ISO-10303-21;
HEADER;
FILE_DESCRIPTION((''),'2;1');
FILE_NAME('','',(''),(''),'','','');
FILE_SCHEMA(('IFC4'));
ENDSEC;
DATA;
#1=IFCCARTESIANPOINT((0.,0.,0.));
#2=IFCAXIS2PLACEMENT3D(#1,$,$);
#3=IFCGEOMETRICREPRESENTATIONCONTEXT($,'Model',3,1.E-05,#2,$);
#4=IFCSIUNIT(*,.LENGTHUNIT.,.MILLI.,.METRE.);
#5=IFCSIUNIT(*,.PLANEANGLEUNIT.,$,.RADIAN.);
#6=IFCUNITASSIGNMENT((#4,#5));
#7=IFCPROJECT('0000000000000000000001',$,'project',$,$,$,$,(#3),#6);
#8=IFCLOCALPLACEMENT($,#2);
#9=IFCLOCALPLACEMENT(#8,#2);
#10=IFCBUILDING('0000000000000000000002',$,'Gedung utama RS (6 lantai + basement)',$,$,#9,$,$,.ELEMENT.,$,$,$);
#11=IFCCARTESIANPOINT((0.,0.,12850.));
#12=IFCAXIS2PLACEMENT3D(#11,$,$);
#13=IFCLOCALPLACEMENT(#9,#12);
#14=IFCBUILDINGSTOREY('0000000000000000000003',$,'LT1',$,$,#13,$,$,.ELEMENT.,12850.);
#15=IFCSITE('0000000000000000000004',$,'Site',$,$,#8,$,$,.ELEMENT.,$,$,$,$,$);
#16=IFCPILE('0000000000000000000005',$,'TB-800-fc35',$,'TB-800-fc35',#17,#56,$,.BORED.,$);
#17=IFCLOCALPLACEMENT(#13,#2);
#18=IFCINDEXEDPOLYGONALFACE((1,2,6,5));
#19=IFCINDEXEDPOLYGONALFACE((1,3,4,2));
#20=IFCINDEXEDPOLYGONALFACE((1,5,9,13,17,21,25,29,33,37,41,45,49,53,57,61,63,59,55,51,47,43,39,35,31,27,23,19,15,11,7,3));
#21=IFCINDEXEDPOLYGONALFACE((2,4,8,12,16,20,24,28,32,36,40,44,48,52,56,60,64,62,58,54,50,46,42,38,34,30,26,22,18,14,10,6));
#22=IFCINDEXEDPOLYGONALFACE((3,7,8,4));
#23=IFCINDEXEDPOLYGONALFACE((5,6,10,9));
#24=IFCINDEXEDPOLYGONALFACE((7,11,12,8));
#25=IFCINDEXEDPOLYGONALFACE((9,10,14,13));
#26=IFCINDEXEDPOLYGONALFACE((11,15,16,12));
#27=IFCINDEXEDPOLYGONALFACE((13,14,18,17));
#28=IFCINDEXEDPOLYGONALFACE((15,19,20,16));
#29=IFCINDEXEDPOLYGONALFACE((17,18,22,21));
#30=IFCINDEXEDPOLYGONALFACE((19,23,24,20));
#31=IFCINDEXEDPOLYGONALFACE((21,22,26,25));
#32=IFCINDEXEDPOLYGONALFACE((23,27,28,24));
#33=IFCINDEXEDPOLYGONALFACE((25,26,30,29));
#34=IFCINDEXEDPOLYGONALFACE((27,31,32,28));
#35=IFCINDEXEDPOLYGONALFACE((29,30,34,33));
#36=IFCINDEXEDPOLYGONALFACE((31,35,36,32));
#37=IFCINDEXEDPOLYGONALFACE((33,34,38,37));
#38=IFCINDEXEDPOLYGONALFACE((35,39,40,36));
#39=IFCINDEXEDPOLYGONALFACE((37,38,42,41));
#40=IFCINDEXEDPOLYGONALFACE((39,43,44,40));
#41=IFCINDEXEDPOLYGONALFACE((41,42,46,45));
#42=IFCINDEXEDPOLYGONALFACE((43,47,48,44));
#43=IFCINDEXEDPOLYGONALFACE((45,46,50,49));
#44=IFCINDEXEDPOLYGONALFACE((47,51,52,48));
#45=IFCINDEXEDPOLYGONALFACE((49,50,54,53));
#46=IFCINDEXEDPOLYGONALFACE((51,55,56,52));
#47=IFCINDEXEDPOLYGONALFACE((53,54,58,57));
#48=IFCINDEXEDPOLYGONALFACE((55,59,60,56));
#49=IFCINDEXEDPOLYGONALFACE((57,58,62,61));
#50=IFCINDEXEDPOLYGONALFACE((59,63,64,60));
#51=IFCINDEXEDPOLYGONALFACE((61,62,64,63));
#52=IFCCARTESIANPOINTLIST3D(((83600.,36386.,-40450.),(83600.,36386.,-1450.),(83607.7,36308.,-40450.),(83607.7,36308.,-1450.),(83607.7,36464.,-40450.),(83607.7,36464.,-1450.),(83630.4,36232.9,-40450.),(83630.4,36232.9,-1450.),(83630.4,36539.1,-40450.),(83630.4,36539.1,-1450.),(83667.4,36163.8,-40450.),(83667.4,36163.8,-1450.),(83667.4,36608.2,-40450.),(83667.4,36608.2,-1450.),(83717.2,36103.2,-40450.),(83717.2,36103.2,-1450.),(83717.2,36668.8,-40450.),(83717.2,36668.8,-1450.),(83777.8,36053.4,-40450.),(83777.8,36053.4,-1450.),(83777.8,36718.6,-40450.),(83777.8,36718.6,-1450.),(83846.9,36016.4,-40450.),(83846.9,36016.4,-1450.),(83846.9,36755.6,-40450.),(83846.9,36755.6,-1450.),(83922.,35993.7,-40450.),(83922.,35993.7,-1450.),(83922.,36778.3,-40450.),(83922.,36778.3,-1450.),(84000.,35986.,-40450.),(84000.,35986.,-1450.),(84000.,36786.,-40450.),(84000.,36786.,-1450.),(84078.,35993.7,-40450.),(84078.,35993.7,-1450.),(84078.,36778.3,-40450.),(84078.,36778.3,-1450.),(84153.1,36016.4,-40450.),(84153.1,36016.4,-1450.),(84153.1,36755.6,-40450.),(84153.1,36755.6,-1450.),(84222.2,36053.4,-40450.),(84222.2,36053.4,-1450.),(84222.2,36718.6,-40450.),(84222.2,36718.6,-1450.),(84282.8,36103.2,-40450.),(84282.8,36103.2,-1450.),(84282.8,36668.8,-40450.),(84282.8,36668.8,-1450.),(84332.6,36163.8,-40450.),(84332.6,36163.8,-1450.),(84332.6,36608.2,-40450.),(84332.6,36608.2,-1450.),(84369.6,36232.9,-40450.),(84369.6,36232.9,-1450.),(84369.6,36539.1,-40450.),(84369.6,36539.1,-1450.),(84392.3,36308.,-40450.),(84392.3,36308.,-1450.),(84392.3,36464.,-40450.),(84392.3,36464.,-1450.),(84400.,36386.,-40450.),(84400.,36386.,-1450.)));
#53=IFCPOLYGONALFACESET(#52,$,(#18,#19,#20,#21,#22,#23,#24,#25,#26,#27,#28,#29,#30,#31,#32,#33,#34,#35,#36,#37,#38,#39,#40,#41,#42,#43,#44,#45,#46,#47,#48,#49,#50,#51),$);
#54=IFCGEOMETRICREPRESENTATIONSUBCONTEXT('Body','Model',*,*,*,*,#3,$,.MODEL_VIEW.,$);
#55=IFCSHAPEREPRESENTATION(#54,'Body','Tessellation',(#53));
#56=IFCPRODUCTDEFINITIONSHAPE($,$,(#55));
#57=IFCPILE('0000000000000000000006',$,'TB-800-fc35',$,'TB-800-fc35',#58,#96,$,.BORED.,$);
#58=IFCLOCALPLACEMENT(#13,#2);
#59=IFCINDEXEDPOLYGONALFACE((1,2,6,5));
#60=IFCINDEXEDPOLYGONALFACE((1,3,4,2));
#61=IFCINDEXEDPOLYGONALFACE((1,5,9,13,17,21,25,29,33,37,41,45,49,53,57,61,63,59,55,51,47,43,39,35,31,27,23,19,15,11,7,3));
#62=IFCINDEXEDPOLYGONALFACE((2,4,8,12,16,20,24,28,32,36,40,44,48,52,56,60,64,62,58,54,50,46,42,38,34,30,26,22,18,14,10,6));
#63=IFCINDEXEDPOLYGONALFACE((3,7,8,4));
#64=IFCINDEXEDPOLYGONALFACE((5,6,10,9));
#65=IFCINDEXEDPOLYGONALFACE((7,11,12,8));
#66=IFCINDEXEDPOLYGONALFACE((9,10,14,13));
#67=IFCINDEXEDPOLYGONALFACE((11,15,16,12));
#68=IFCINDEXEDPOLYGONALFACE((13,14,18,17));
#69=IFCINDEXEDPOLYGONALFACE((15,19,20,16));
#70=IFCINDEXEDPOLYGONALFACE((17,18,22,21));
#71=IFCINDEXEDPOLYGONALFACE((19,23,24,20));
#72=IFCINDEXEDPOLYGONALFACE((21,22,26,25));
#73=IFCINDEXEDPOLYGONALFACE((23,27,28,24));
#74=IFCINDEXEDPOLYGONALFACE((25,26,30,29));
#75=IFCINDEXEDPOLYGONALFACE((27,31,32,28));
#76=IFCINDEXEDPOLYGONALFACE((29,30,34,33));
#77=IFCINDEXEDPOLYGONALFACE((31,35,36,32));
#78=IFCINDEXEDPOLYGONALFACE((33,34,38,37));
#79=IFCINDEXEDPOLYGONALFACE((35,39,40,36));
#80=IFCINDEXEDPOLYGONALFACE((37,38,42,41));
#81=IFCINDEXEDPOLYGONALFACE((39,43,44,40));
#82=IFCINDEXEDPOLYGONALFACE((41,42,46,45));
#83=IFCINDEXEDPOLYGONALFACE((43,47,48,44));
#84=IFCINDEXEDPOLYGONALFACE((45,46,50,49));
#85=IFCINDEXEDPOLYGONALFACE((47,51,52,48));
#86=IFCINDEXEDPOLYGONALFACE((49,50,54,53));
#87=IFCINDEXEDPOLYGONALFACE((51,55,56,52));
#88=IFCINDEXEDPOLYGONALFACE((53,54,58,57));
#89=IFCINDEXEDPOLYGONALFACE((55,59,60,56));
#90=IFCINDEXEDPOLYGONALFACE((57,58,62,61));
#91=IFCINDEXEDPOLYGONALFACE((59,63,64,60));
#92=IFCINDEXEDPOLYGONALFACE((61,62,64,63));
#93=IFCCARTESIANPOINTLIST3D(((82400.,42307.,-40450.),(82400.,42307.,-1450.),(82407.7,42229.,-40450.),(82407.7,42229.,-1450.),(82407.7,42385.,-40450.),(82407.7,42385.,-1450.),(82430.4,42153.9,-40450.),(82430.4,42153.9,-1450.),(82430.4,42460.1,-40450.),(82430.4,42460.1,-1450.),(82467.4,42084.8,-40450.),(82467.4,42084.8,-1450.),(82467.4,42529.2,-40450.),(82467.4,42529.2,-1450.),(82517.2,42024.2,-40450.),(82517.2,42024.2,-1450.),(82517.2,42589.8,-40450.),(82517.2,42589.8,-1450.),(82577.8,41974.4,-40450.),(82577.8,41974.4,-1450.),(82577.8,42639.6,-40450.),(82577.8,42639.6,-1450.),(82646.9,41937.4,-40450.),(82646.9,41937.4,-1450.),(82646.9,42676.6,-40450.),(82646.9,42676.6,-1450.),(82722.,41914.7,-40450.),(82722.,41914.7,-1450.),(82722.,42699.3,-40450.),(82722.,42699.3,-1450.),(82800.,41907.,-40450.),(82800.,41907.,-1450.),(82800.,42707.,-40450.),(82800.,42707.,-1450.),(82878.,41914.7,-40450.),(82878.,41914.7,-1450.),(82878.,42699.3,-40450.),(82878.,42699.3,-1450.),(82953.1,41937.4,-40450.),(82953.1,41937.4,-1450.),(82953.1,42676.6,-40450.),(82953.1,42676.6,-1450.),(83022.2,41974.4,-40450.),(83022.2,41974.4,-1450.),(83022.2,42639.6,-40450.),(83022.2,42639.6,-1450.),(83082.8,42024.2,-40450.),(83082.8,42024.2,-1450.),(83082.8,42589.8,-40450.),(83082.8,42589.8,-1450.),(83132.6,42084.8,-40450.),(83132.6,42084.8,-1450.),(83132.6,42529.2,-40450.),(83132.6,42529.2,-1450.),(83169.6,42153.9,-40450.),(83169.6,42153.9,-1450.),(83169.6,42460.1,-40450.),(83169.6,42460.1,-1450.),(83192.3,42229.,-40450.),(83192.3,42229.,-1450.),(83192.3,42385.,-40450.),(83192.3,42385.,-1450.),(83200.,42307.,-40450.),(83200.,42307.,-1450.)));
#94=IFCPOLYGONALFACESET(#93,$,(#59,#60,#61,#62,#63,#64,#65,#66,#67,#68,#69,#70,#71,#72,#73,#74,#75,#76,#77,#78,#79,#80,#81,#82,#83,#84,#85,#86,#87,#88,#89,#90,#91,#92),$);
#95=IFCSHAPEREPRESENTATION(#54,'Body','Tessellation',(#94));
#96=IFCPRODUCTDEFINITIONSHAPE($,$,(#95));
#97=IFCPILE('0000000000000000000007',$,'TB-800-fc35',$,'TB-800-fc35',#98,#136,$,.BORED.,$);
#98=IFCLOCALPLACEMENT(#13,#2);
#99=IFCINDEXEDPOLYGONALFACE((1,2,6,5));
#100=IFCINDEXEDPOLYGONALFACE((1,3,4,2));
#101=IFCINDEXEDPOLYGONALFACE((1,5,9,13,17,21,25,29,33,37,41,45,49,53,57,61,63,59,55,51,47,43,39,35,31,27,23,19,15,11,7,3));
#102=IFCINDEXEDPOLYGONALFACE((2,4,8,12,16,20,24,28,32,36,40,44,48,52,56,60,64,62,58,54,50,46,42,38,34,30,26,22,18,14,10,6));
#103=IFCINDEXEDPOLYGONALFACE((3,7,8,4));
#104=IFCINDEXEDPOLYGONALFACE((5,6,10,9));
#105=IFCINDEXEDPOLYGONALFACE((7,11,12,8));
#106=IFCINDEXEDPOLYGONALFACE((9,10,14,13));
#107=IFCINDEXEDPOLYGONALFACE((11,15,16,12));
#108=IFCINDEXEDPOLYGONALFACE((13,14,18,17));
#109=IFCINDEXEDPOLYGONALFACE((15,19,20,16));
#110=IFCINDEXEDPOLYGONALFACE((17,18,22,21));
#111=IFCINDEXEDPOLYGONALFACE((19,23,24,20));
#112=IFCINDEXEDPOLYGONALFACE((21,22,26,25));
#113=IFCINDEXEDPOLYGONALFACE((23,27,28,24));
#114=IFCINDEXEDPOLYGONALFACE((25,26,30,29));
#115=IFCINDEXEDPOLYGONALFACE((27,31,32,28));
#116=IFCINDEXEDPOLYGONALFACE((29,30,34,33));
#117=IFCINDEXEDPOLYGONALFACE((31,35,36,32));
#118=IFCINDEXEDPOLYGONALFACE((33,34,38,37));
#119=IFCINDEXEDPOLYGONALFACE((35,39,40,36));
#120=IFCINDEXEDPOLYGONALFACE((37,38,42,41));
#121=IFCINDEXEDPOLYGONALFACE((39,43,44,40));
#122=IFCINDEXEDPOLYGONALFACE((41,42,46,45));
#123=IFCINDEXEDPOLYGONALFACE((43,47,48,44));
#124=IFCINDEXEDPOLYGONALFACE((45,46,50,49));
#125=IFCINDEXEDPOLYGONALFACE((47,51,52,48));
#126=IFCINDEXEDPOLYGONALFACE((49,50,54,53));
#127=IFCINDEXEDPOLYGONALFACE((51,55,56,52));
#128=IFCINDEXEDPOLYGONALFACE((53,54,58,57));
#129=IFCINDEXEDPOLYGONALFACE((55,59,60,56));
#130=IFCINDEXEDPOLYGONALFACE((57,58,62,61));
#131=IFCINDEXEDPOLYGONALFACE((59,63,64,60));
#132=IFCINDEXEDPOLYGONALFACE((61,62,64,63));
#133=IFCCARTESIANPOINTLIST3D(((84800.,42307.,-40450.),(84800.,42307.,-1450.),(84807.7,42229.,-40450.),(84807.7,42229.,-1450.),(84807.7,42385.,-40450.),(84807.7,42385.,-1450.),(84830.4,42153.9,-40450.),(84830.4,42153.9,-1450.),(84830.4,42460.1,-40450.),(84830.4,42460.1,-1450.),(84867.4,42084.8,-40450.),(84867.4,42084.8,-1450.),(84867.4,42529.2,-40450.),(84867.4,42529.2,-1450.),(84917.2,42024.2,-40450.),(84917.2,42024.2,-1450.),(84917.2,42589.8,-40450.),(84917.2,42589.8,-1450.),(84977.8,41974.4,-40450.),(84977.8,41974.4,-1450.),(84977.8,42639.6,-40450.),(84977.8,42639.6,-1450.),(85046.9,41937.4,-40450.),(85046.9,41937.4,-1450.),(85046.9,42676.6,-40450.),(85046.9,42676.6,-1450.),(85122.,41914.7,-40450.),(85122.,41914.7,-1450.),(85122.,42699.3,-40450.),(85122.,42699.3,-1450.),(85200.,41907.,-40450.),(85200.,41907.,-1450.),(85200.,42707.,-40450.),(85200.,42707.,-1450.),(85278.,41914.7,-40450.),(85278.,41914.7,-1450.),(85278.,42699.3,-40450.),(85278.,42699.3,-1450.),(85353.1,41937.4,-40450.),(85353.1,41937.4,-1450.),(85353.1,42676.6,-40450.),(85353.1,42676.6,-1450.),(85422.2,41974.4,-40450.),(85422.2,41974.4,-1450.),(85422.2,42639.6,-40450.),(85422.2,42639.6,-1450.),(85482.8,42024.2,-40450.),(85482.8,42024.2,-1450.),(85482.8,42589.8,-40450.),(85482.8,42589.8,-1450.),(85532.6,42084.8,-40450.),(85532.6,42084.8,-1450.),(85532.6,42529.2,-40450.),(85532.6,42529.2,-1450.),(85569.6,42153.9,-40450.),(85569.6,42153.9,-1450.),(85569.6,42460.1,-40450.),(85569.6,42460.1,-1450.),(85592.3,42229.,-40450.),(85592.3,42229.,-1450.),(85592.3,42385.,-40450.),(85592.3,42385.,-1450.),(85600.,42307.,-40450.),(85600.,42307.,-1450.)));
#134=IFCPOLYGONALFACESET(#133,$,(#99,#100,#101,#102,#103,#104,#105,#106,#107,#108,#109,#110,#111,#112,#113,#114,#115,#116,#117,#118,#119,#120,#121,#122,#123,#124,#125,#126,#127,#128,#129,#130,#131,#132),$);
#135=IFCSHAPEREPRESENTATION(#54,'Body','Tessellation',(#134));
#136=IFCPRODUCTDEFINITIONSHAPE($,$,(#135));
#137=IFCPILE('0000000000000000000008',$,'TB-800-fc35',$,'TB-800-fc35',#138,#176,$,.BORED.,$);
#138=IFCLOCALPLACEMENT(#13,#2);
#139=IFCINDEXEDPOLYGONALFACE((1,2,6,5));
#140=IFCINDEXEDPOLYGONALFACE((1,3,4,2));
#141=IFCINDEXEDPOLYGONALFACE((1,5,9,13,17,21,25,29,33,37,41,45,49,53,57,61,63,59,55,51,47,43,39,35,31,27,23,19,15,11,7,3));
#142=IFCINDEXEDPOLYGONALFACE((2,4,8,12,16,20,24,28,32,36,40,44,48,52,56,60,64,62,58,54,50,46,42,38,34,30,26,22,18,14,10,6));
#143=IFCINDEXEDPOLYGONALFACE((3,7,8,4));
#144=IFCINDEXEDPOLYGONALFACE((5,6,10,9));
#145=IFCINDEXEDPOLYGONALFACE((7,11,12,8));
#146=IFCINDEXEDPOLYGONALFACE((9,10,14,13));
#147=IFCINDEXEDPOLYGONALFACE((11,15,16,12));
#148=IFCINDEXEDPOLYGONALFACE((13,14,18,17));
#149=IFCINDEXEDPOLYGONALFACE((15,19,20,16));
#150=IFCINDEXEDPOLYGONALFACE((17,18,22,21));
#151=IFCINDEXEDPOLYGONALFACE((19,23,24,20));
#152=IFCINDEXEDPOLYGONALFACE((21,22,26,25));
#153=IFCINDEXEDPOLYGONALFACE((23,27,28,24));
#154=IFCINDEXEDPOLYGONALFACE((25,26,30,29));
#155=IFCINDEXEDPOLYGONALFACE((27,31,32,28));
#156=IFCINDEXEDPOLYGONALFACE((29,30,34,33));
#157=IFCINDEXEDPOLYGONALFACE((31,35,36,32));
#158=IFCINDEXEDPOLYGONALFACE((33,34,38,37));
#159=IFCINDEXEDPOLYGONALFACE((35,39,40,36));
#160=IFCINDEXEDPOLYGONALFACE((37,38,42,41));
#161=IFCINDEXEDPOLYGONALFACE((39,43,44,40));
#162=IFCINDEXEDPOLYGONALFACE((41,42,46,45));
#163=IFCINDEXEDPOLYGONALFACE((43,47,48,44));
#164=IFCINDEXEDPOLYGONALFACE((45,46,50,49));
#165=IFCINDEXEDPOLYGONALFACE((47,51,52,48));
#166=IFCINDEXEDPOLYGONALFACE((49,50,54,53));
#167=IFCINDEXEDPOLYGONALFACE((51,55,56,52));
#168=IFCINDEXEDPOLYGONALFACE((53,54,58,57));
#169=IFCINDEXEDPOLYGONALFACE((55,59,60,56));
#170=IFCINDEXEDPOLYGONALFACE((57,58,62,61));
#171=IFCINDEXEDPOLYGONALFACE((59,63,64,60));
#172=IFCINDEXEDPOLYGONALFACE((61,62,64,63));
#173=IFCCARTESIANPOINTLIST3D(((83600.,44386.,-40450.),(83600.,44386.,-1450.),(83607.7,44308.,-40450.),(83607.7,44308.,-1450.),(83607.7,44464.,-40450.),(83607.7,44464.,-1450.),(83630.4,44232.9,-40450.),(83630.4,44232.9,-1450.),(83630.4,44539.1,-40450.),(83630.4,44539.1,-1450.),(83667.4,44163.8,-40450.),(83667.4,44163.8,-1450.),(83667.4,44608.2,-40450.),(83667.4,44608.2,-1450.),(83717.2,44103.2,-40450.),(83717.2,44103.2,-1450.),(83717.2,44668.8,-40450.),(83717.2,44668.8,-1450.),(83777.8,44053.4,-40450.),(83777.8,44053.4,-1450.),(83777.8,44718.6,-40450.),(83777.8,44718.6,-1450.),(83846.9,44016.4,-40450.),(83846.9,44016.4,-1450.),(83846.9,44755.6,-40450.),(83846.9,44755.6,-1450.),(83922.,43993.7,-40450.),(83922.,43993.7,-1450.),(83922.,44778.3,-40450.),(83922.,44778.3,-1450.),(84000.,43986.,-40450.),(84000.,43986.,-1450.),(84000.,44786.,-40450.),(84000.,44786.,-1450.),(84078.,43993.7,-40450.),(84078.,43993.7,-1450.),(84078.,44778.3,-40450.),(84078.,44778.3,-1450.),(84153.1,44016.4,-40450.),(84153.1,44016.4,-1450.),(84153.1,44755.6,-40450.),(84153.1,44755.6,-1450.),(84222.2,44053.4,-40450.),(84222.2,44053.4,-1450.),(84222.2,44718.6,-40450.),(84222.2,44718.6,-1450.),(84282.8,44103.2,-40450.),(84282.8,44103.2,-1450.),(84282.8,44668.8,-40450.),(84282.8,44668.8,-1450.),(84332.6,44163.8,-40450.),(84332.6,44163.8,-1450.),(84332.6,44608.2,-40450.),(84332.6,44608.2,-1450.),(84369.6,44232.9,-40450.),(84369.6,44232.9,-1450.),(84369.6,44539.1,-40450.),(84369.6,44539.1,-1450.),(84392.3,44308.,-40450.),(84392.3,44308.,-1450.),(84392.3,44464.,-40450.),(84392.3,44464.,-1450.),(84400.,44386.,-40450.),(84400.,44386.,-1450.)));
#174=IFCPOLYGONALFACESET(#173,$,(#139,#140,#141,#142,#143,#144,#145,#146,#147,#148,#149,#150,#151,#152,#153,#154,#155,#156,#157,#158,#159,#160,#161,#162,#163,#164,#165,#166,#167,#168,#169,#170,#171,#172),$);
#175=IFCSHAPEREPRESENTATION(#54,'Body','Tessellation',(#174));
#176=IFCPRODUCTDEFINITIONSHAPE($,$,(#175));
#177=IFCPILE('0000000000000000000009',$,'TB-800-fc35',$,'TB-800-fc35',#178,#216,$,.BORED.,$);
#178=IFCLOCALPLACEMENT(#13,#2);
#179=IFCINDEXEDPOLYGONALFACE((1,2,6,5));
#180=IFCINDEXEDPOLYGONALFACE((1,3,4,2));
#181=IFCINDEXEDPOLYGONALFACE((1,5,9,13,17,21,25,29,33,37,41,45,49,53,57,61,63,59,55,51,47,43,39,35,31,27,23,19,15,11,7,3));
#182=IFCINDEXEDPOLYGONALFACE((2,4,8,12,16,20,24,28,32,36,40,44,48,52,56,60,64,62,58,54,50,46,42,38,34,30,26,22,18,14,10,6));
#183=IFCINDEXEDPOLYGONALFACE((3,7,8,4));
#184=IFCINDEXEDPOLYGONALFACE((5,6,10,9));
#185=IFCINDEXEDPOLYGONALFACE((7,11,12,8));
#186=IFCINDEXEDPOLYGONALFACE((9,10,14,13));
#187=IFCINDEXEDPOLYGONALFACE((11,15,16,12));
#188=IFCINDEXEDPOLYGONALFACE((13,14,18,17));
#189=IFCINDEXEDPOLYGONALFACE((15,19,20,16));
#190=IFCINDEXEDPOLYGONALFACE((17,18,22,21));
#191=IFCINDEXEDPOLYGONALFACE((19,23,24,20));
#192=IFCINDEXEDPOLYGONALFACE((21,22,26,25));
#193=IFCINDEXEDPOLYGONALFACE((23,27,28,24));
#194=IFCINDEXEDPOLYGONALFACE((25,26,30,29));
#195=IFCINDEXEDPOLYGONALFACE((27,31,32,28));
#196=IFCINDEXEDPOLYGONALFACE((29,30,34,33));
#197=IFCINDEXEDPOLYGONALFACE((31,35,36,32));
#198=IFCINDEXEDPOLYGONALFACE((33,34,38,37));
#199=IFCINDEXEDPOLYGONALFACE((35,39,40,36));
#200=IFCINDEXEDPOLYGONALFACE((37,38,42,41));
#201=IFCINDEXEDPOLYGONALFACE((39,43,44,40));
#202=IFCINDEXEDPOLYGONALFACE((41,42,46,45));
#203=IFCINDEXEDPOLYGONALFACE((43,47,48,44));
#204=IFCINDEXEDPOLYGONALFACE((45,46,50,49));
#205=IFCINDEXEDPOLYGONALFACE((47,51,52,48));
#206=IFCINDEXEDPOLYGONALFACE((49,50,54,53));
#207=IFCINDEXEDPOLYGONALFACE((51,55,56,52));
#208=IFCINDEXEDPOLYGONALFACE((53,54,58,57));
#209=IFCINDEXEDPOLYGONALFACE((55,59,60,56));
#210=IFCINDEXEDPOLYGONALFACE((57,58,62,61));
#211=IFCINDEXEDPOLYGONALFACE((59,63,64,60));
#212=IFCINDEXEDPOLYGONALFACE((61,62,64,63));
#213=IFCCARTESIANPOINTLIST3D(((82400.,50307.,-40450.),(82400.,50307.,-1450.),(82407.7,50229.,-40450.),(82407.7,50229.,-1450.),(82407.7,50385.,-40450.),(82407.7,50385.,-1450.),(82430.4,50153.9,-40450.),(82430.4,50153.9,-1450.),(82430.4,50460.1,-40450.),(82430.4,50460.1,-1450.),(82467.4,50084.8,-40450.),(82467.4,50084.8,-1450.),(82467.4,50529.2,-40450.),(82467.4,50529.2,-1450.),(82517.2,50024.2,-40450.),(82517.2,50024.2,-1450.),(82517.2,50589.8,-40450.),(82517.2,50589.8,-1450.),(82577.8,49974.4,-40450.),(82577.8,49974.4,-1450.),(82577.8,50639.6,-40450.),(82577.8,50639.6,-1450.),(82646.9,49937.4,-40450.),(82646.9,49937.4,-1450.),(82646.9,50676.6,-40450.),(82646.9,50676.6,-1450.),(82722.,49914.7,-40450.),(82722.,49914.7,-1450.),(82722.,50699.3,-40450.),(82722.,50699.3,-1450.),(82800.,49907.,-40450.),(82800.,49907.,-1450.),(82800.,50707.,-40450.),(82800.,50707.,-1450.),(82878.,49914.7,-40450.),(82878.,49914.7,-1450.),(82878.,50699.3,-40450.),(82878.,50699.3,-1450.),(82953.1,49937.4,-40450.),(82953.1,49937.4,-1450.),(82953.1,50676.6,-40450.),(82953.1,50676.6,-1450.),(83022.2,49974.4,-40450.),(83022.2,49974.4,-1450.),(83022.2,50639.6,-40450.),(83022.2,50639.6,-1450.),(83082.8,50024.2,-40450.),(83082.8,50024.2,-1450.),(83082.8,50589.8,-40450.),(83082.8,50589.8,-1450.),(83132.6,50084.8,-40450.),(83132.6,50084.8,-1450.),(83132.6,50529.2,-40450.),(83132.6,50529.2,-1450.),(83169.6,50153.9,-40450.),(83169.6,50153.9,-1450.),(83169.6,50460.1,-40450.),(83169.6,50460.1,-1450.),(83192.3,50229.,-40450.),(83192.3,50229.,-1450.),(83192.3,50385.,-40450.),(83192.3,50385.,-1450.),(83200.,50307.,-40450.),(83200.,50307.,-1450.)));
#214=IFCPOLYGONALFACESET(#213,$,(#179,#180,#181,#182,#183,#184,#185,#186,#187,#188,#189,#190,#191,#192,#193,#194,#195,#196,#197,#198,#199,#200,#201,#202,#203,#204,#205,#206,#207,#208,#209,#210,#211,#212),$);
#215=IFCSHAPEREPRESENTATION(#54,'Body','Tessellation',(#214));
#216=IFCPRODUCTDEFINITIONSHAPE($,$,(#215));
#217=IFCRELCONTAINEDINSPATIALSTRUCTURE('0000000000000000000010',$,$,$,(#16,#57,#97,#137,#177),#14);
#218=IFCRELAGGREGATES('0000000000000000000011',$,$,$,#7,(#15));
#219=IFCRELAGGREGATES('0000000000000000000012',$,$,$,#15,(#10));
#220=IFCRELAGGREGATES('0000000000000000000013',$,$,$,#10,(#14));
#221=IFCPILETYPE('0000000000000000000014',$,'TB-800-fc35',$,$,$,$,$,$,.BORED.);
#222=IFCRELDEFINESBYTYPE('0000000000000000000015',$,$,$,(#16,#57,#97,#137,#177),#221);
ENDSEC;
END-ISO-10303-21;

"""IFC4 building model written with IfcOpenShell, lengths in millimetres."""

from ifc_helpers import new_model, si_unit, frame, origin, origin_2d, place, context, subcontext, project, spatial, circle, extrude, material_profile, profile_set, profile_usage, type_object, element, save


model = new_model("IFC4")

# Units and contexts
model_context = context("Model", 3, precision=1e-05, world=origin())
body_context = subcontext(model_context, "Body", "Model", "MODEL_VIEW")
ifc_project = project(units=[si_unit("LENGTHUNIT", "METRE", prefix="MILLI"), si_unit("PLANEANGLEUNIT", "RADIAN")], contexts=[model_context])

# Site, building, storey
site_placement = place(None, origin())
site = spatial("IfcSite", under=ifc_project, at=site_placement, Name="Site", CompositionType="ELEMENT")
building_placement = place(site_placement, origin())
building = spatial("IfcBuilding", under=site, at=building_placement, Name="Gedung utama RS (6 lantai + basement)", CompositionType="ELEMENT")
storey_placement = place(building_placement, frame((0.0, 0.0, 12850.0)))
storey = spatial("IfcBuildingStorey", under=building, at=storey_placement, Name="LT1", CompositionType="ELEMENT", Elevation=12850.0)

# Piles
ifc_material_profile_1 = material_profile(None, circle(Radius=400.0, at=origin_2d()), Name="TB-800-fc35")
ifc_profile_set_1 = profile_set([ifc_material_profile_1], Name="TB-800-fc35")
ifc_profile_usage_1 = profile_usage(ifc_profile_set_1, cardinal=5)
pile_type = type_object("IfcPileType", Name="TB-800-fc35", PredefinedType="BORED", material=ifc_profile_set_1)
for number, where, z_axis, x_axis, name in (
    (1, (84000.0, 36386.0, -40450.0), (0.0, 0.0, 1.0), (1.0, 0.0, 0.0), "TB-800-fc35"),
    (2, (82800.0, 42307.0, -40450.0), (0.0, 0.0, 1.0), (1.0, 0.0, 0.0), "TB-800-fc35"),
    (3, (85200.0, 42307.0, -40450.0), (0.0, 0.0, 1.0), (1.0, 0.0, 0.0), "TB-800-fc35"),
    (4, (84000.0, 44386.0, -40450.0), (0.0, 0.0, 1.0), (1.0, 0.0, 0.0), "TB-800-fc35"),
    (5, (82800.0, 50307.0, -40450.0), (0.0, 0.0, 1.0), (1.0, 0.0, 0.0), "TB-800-fc35"),
):
    element("IfcPile", number, at=place(storey_placement, frame(where, z_axis=z_axis, x_axis=x_axis)), inside=storey, type_object=pile_type, material=ifc_profile_usage_1, Name=name, ObjectType="TB-800-fc35", PredefinedType="BORED", context=body_context, shape_type="SweptSolid", body=[
        extrude(circle(Radius=400.0, at=origin_2d()), origin(), (0.0, 0.0, 1.0), 39000.0),
    ])

save(model, "model.ifc")
